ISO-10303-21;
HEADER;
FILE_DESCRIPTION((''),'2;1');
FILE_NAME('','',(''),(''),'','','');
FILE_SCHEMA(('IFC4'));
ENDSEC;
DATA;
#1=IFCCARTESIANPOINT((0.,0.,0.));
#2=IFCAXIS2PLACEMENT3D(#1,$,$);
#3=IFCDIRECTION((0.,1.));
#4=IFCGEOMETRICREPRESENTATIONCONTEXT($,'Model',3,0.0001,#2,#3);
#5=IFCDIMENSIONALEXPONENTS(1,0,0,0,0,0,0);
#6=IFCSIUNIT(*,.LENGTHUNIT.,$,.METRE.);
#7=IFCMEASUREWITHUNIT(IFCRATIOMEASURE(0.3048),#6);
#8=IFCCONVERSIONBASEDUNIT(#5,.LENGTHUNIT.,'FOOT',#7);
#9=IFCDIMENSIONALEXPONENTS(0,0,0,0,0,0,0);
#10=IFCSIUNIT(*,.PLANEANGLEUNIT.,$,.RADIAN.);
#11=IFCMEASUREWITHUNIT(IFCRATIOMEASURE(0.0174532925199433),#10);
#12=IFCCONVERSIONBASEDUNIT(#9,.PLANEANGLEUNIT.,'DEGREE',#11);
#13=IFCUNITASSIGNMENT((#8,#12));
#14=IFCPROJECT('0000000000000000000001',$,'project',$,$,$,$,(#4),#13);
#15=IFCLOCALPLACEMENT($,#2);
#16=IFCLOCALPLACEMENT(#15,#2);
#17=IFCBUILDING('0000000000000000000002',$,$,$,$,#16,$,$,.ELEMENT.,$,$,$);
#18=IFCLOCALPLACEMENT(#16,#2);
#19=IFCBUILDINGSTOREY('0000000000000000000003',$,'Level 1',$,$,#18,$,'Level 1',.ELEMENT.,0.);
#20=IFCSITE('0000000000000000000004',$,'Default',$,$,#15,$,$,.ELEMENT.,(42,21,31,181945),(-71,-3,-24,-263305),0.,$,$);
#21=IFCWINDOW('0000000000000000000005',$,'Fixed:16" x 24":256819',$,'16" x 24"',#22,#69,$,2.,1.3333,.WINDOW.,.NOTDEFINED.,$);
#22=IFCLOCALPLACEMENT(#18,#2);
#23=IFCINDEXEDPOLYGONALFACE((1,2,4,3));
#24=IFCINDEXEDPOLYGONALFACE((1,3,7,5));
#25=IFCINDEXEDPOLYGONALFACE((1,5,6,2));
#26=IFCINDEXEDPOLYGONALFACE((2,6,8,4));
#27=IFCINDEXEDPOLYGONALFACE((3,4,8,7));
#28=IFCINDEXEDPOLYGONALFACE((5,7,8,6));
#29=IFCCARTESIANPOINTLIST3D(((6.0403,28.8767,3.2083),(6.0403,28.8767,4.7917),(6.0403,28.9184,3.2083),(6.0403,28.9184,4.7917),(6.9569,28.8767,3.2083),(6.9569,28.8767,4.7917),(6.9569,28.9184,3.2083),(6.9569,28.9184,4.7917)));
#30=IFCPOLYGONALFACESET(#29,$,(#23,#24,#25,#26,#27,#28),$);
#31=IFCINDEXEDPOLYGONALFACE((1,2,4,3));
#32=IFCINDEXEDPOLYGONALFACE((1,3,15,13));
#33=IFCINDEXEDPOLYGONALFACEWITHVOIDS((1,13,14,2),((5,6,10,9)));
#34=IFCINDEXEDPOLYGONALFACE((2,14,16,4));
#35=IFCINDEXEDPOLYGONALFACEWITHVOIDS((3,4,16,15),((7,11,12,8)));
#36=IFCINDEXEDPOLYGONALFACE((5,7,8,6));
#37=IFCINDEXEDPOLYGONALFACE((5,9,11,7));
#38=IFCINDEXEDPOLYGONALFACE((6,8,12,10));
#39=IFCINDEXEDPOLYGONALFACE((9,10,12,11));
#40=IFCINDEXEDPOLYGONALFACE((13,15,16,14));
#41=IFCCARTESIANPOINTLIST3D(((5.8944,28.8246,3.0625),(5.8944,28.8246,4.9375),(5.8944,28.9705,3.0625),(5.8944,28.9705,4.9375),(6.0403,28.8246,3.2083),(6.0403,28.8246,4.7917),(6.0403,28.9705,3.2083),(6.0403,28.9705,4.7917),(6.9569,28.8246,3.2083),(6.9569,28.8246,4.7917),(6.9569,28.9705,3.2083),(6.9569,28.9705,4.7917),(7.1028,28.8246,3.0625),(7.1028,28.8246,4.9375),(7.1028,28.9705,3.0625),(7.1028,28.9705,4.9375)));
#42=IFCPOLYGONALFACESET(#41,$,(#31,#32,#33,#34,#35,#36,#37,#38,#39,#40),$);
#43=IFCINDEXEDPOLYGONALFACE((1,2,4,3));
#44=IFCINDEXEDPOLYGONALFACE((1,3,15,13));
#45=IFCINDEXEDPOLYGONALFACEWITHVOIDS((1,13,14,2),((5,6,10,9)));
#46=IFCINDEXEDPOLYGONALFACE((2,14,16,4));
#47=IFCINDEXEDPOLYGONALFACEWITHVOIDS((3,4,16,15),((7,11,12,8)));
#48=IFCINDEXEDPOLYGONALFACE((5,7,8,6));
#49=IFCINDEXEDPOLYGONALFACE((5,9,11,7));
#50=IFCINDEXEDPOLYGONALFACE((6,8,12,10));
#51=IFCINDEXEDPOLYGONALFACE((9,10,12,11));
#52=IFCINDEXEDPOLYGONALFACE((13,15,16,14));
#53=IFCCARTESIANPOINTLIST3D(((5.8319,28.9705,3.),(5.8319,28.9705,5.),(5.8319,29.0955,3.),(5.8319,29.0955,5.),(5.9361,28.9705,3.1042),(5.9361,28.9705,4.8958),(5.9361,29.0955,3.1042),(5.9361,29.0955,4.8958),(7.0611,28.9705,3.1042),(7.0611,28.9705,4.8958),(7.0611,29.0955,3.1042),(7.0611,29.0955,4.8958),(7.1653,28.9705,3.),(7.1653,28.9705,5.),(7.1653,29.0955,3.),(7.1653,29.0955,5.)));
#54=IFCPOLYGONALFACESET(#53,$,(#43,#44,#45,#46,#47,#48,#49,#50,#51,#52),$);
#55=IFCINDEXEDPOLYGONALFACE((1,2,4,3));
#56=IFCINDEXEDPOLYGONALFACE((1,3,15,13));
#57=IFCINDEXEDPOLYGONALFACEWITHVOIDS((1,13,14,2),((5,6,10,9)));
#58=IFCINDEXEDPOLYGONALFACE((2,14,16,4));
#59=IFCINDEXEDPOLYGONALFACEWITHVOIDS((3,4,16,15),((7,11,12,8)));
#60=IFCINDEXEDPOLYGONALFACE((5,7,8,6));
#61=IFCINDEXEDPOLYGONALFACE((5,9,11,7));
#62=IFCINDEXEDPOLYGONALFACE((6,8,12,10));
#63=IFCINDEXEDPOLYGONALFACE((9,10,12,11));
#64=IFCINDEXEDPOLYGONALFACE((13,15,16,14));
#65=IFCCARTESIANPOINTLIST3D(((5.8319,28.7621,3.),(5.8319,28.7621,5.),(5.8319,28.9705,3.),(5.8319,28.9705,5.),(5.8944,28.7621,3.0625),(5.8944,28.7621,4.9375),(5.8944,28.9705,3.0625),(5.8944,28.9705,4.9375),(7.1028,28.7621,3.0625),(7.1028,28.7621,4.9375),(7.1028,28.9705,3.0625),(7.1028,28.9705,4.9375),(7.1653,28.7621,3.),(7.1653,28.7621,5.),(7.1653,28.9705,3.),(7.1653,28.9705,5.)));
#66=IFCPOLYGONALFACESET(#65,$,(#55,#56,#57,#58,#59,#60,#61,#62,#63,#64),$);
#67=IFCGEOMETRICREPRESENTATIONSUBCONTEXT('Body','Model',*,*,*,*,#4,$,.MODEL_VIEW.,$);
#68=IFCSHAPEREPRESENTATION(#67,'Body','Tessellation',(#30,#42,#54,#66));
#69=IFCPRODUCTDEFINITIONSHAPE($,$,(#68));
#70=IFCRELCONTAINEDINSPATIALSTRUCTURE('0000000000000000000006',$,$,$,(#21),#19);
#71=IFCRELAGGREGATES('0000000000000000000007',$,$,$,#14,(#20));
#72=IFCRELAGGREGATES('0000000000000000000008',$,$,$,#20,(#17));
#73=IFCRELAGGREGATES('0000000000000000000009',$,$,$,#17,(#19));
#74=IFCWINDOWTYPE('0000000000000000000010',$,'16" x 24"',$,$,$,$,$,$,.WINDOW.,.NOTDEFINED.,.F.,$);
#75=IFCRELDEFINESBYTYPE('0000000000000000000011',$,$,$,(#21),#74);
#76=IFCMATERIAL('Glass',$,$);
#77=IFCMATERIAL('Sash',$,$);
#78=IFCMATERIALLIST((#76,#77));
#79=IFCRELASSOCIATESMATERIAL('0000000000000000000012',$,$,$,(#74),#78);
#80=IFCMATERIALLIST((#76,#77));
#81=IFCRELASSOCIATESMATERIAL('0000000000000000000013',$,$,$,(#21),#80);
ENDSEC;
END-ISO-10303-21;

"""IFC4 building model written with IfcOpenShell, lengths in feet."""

from ifc_helpers import new_model, entity, si_unit, converted_unit, direction, frame, origin, origin_2d_with_axis, place, context, subcontext, project, spatial, polyline, rectangle, outline, extrude, source, transform, mapped, material, material_list, type_object, type_shapes, element, save


model = new_model("IFC4")

# Units and contexts
model_context = context("Model", 3, precision=0.0001, world=origin(), true_north=direction((0.0, 1.0)))
body_context = subcontext(model_context, "Body", "Model", "MODEL_VIEW")
ifc_project = project(units=[converted_unit("LENGTHUNIT", "FOOT", entity("IfcRatioMeasure", 0.3048), si_unit("LENGTHUNIT", "METRE"), dimensions=[1, 0, 0, 0, 0, 0, 0]), converted_unit("PLANEANGLEUNIT", "DEGREE", entity("IfcRatioMeasure", 0.0174532925199433), si_unit("PLANEANGLEUNIT", "RADIAN"), dimensions=[0, 0, 0, 0, 0, 0, 0])], contexts=[model_context])

# Site, building, storey
site_placement = place(None, origin())
site = spatial("IfcSite", under=ifc_project, at=site_placement, Name="Default", CompositionType="ELEMENT", RefLatitude=(42, 21, 31, 181945), RefLongitude=(-71, -3, -24, -263305), RefElevation=0.0)
building_placement = place(site_placement, origin())
building = spatial("IfcBuilding", under=site, at=building_placement, CompositionType="ELEMENT")
storey_placement = place(building_placement, origin())
storey = spatial("IfcBuildingStorey", under=building, at=storey_placement, Name="Level 1", LongName="Level 1", CompositionType="ELEMENT", Elevation=0.0)

# Shared definitions
placement_1 = place(storey_placement, frame((-0.1681, 28.9288, 0.0)))

# Window
ifc_material_1 = material(Name="Glass")
ifc_material_2 = material(Name="Sash")
ifc_material_list_1 = material_list([ifc_material_1, ifc_material_2])
ifc_material_list_2 = material_list([ifc_material_1, ifc_material_2])
window_type = type_object("IfcWindowType", Name="16\" x 24\"", ParameterTakesPrecedence=False, PartitioningType="NOTDEFINED", PredefinedType="WINDOW", material=ifc_material_list_2)
shared_shape = source(origin(), body_context, "Body", "SweptSolid", [
    extrude(rectangle(XDim=0.0417, YDim=0.9167, at=origin_2d_with_axis()), frame((0.6667, 0.1979, 0.2083), z_axis=(0.0, 0.0, 1.0), x_axis=(0.0, 1.0, 0.0)), (0.0, 0.0, 1.0), 1.5833),
    extrude(outline(polyline([(-0.6042, -0.9375), (0.6042, -0.9375), (0.6042, 0.9375), (-0.6042, 0.9375), (-0.6042, -0.9375)]), holes=[polyline([(-0.4583, -0.7917), (-0.4583, 0.7917), (0.4583, 0.7917), (0.4583, -0.7917), (-0.4583, -0.7917)])]), frame((0.6667, 0.125, 1.0), z_axis=(0.0, 1.0, 0.0), x_axis=(1.0, 0.0, 0.0)), (0.0, 0.0, 1.0), 0.1458),
    extrude(outline(polyline([(-0.6667, -1.0), (0.6667, -1.0), (0.6667, 1.0), (-0.6667, 1.0), (-0.6667, -1.0)]), holes=[polyline([(-0.5625, -0.8958), (-0.5625, 0.8958), (0.5625, 0.8958), (0.5625, -0.8958), (-0.5625, -0.8958)])]), frame((0.6667, 0.0, 1.0), z_axis=(0.0, 1.0, 0.0), x_axis=(1.0, 0.0, 0.0)), (0.0, 0.0, 1.0), 0.125),
    extrude(outline(polyline([(-1.0, -0.6667), (1.0, -0.6667), (1.0, 0.6667), (-1.0, 0.6667), (-1.0, -0.6667)]), holes=[polyline([(-0.9375, -0.6042), (-0.9375, 0.6042), (0.9375, 0.6042), (0.9375, -0.6042), (-0.9375, -0.6042)])]), frame((0.6667, 0.125, 1.0), z_axis=(0.0, 1.0, 0.0), x_axis=(0.0, 0.0, -1.0)), (0.0, 0.0, 1.0), 0.2083),
])
type_shapes(window_type, [shared_shape])
placement_2 = place(placement_1, frame((7.3333, 0.1667, 3.0)))
window_placement = place(placement_2, frame((0.0, 0.0, 0.0), z_axis=(0.0, 0.0, 1.0), x_axis=(-1.0, 0.0, 0.0)))
element("IfcWindow", 1, at=window_placement, inside=storey, type_object=window_type, material=ifc_material_list_1, Name="Fixed:16\" x 24\":256819", ObjectType="16\" x 24\"", OverallHeight=2.0, OverallWidth=1.3333, PartitioningType="NOTDEFINED", PredefinedType="WINDOW", context=body_context, shape_type="MappedRepresentation", body=[
    mapped(shared_shape, transform((0.0, 0.0, 0.0), scale=1.0)),
])

save(model, "model.ifc")
